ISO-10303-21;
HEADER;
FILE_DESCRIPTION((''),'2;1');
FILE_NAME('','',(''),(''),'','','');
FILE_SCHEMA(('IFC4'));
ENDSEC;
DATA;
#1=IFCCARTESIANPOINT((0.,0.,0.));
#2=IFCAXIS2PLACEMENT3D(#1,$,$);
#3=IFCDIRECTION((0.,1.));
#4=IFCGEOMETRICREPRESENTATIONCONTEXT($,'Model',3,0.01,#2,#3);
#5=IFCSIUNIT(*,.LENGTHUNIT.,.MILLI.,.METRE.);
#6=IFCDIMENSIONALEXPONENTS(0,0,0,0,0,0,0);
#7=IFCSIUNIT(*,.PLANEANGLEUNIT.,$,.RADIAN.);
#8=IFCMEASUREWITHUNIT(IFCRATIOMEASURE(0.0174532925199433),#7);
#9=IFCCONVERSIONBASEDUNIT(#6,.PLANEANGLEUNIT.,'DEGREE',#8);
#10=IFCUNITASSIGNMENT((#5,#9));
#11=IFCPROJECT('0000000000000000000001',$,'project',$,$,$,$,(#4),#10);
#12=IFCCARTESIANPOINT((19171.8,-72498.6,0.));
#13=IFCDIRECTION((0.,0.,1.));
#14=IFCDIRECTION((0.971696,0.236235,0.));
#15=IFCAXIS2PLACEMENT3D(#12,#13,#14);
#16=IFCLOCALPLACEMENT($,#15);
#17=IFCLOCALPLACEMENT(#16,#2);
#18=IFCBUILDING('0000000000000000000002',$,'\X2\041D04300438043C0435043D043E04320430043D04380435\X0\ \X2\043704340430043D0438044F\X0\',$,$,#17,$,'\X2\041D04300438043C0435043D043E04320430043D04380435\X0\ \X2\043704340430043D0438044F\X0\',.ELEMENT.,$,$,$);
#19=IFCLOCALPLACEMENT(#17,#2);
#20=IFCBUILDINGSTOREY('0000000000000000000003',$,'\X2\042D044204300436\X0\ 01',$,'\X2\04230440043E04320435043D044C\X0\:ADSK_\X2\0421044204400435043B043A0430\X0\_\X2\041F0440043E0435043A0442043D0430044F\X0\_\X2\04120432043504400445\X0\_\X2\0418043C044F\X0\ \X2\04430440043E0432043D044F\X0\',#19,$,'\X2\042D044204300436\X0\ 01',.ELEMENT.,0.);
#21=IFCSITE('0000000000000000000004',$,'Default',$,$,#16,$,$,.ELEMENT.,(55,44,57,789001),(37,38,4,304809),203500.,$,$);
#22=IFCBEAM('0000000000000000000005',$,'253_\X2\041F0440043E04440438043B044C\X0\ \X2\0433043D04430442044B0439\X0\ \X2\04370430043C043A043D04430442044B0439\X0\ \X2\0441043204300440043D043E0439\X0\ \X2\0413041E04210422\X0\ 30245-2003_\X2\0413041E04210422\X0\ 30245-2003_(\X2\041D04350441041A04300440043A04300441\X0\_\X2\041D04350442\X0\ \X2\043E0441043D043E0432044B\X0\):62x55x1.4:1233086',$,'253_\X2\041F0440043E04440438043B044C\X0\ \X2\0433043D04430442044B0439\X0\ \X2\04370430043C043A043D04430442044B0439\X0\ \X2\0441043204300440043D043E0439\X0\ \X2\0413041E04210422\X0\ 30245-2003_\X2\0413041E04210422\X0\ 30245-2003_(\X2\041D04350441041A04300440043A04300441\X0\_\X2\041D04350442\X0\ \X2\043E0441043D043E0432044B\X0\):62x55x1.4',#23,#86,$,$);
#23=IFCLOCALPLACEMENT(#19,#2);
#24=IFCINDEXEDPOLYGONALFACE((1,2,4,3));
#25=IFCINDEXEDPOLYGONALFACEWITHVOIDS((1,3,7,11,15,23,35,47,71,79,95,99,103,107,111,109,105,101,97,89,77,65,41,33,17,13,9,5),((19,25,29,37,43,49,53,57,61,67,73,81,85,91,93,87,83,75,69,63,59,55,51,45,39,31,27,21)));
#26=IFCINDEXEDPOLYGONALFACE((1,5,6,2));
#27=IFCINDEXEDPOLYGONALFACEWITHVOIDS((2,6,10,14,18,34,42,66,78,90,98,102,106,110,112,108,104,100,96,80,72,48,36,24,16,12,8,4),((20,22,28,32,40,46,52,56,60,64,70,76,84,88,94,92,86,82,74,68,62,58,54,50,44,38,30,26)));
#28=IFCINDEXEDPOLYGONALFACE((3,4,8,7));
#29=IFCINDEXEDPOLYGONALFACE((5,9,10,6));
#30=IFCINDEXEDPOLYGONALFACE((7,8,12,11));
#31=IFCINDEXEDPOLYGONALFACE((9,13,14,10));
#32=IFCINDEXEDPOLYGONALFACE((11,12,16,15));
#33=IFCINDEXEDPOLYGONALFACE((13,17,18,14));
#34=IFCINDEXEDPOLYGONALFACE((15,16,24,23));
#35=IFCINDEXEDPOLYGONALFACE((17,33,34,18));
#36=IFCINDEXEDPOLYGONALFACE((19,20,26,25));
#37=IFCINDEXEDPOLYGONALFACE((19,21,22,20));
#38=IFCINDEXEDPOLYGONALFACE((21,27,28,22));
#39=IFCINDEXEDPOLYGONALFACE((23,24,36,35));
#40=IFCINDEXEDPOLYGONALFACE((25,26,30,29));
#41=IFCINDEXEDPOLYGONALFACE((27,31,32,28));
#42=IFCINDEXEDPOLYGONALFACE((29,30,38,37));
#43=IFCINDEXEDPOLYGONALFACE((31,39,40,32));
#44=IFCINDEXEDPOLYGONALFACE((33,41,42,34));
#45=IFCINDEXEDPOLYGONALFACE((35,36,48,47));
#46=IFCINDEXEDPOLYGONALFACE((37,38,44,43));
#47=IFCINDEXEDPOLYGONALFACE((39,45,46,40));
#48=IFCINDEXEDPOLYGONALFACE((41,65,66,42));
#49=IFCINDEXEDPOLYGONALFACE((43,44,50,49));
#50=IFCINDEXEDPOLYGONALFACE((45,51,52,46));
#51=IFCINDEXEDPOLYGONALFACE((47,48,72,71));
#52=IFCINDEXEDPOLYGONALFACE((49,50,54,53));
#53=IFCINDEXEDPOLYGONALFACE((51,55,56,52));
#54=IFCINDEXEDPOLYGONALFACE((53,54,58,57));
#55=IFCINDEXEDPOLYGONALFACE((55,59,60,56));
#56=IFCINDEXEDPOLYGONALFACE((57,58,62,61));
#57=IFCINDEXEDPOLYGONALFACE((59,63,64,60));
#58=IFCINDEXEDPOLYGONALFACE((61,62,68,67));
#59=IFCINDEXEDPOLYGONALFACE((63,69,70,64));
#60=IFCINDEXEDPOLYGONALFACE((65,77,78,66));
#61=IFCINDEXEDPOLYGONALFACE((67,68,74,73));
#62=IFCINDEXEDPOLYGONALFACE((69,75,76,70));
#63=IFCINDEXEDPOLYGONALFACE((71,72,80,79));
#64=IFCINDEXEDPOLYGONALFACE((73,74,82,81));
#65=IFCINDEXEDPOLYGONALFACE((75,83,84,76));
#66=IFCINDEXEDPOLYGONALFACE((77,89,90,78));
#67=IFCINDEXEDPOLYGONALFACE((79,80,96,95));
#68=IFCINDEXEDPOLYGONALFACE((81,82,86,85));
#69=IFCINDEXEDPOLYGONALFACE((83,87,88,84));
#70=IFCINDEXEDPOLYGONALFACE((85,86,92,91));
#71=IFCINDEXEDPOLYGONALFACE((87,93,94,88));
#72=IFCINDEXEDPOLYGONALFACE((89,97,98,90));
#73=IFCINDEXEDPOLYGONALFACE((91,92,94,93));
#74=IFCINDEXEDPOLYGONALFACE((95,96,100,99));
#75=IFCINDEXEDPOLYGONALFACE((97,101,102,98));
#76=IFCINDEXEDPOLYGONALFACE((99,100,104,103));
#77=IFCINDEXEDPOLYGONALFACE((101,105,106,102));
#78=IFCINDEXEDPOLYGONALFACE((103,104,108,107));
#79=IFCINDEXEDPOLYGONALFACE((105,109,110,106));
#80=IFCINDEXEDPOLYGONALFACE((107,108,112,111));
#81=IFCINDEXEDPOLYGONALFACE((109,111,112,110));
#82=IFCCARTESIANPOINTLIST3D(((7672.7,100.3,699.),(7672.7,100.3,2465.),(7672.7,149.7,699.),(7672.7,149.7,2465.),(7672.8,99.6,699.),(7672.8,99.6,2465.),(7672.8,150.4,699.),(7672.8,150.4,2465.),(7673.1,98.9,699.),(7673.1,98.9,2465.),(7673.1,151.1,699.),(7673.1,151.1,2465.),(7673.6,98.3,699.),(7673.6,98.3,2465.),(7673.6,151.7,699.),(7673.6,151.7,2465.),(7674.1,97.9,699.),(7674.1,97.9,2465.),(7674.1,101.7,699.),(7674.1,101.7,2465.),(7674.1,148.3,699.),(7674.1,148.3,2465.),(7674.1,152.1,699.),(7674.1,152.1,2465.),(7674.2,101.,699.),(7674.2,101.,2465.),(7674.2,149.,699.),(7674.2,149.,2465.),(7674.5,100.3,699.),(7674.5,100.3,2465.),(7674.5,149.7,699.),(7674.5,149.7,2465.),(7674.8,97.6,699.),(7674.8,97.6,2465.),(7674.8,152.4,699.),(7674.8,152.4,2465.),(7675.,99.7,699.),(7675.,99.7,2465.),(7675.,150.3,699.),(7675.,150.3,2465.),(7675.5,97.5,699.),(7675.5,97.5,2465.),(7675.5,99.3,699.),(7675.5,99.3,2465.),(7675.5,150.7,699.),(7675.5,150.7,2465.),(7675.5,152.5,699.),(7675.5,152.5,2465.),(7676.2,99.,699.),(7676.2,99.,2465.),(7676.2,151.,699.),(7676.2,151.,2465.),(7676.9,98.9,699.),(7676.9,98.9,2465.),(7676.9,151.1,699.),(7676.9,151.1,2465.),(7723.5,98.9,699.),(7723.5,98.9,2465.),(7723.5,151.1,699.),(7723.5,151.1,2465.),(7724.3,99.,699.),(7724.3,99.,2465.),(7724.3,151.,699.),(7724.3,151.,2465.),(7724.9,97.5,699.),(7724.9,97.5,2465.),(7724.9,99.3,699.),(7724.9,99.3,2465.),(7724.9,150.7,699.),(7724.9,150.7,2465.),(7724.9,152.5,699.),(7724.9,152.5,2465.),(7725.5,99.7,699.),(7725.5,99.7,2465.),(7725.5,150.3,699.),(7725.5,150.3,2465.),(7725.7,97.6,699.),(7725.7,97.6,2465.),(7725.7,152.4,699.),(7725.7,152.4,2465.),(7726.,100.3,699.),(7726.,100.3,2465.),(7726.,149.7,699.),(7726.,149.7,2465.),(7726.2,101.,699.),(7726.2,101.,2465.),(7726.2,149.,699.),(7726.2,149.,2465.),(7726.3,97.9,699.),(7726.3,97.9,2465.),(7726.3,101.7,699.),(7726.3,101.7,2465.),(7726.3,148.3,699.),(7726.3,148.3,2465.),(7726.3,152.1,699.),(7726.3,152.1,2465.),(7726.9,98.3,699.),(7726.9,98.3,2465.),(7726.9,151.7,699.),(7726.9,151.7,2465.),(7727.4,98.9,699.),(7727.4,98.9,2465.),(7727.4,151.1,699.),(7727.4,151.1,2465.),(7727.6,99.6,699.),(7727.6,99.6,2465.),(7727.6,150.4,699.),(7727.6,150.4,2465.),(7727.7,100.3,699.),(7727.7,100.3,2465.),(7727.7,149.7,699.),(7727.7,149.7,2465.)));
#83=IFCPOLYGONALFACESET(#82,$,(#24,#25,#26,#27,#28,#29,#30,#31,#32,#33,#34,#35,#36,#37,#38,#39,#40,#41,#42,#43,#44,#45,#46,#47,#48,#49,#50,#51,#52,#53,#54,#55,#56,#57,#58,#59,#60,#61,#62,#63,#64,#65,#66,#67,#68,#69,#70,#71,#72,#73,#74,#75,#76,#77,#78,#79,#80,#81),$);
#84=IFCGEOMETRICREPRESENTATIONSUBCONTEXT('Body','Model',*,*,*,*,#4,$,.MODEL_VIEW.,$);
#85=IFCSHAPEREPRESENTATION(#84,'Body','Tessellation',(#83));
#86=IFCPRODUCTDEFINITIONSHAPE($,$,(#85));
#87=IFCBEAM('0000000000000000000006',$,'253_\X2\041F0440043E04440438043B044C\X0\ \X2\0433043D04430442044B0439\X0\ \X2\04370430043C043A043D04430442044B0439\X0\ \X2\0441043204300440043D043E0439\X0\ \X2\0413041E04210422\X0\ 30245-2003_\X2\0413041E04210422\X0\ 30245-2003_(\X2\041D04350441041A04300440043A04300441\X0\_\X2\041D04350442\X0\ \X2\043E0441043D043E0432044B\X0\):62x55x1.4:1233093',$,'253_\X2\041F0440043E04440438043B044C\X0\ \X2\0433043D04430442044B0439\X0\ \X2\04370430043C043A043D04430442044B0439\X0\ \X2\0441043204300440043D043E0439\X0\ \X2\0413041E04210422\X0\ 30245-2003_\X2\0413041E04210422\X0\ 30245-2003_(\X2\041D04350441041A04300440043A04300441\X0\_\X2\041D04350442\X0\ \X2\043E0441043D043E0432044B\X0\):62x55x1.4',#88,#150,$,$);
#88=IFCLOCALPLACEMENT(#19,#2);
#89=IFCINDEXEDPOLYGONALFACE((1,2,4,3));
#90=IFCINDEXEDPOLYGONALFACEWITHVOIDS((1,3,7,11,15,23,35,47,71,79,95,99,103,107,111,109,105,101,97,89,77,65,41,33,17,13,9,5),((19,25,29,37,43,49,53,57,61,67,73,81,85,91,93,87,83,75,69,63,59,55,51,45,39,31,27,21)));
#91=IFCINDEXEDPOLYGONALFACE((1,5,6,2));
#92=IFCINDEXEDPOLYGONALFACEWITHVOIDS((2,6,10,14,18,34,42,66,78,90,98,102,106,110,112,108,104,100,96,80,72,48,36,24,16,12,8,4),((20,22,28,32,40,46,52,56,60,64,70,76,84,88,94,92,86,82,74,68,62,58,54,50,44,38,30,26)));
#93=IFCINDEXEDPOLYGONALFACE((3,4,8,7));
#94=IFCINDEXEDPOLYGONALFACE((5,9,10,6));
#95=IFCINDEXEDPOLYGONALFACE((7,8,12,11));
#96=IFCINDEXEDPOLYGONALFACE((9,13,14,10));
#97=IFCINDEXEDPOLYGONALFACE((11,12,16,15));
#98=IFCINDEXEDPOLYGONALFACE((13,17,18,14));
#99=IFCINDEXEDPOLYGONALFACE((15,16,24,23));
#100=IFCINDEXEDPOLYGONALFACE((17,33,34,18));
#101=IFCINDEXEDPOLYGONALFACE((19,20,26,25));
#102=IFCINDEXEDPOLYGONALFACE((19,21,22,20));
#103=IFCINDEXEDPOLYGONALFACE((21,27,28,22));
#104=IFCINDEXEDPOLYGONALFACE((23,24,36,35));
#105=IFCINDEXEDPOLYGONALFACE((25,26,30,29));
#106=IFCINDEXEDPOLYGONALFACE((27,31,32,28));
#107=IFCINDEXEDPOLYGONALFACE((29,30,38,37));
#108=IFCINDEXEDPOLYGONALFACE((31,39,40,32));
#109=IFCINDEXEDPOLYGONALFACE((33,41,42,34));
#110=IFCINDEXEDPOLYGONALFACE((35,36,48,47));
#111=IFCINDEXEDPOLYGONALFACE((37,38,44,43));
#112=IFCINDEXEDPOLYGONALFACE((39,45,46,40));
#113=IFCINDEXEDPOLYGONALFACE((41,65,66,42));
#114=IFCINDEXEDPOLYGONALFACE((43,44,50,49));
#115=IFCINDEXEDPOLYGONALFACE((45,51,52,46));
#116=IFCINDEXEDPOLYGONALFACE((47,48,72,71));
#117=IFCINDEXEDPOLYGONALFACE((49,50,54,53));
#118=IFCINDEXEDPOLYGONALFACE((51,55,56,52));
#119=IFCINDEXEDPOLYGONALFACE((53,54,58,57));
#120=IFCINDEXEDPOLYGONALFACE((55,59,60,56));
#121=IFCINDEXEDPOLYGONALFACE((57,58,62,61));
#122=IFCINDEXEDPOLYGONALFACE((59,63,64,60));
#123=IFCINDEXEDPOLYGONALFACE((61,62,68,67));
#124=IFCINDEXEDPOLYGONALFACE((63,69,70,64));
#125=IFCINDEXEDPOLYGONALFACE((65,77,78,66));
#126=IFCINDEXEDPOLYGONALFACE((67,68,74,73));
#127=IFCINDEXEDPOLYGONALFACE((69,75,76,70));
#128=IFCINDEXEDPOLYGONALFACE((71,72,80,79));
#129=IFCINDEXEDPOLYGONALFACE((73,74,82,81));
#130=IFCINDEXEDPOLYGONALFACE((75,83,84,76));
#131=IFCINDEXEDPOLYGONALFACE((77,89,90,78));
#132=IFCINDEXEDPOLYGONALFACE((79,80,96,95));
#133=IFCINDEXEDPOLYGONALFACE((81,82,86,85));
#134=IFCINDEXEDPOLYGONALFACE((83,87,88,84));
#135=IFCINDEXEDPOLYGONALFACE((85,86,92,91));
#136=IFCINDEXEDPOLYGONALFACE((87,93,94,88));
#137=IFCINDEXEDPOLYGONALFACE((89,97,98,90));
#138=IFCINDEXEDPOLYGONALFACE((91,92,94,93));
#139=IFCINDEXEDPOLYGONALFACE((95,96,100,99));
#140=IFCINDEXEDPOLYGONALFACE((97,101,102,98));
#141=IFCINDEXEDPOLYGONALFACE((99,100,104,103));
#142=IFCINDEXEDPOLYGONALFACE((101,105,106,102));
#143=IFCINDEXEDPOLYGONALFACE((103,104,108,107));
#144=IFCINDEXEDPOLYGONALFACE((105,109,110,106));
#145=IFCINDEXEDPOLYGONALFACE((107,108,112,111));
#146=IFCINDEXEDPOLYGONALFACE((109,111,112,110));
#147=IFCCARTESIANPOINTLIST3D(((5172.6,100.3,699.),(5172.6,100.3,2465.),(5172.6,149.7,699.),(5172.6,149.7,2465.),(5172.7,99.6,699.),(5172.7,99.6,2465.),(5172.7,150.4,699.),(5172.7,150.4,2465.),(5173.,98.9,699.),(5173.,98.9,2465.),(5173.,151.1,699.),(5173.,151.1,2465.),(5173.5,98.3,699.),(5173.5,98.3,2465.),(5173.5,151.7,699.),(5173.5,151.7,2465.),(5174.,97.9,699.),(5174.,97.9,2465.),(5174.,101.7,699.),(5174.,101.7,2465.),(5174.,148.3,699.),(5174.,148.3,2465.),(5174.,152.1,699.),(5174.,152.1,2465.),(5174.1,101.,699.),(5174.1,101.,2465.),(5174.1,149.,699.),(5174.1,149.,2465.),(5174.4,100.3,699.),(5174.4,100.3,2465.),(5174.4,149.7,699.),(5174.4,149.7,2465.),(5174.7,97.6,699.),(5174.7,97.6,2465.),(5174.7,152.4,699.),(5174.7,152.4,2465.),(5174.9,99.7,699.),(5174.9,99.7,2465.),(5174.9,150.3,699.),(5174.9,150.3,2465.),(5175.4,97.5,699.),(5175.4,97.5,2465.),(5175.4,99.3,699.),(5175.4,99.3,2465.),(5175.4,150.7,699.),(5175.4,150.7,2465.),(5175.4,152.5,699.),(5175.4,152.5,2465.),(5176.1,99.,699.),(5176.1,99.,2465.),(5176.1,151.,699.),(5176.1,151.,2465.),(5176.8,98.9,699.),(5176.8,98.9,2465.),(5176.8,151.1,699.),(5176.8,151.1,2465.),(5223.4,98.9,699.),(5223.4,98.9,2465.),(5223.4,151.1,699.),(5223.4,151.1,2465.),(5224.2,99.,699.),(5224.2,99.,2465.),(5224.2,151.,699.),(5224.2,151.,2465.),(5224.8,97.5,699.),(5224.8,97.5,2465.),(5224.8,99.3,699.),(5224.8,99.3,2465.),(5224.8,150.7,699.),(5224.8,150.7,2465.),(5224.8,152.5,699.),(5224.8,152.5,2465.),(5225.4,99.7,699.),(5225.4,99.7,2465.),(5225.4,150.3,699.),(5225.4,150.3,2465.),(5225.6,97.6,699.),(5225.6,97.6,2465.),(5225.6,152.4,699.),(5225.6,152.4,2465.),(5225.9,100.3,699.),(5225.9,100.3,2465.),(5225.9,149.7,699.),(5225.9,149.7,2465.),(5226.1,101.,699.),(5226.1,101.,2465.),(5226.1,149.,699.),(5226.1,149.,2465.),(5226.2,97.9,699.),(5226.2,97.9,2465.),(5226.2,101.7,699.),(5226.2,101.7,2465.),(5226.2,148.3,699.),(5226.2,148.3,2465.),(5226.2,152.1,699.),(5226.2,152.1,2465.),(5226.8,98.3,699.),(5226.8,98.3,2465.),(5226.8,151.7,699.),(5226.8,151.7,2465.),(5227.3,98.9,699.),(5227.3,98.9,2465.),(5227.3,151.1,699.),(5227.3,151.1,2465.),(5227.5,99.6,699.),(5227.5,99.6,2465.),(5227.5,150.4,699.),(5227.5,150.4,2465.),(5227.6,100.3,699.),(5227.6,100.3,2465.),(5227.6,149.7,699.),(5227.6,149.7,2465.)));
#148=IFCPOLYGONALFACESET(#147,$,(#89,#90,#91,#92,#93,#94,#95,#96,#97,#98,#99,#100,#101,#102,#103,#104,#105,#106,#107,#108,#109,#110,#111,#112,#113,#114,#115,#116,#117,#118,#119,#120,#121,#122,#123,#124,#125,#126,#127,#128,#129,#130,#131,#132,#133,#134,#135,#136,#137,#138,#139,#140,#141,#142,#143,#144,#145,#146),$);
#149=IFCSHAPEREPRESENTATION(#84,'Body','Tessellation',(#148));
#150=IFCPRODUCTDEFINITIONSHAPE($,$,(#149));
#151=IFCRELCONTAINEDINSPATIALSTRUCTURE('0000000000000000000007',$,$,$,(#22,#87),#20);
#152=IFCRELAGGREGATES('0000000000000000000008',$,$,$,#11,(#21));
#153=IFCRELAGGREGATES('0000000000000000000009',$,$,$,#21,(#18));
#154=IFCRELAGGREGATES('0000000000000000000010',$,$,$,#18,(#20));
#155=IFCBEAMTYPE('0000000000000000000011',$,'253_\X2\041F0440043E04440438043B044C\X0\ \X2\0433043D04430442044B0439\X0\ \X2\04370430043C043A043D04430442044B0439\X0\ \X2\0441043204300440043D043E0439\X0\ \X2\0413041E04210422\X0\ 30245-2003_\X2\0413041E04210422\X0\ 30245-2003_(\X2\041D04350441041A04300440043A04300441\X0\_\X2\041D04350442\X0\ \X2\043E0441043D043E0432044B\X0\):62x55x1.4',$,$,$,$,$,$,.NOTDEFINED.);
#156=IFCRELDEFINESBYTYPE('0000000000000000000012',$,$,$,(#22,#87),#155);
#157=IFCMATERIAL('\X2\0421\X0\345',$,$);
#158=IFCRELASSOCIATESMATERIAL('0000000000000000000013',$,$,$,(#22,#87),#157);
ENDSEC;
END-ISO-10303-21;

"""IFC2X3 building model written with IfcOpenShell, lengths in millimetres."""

from ifc_helpers import new_model, entity, si_unit, converted_unit, direction, frame, frame_2d, origin, place, context, subcontext, project, spatial, polyline, circle_curve, parameter, trimmed, segment, composite_curve, outline, extrude, material, type_object, element, save


model = new_model("IFC2X3")

# Units and contexts
model_context = context("Model", 3, precision=0.01, world=origin(), true_north=direction((0.0, 1.0)))
body_context = subcontext(model_context, "Body", "Model", "MODEL_VIEW")
ifc_project = project(units=[si_unit("LENGTHUNIT", "METRE", prefix="MILLI"), converted_unit("PLANEANGLEUNIT", "DEGREE", entity("IfcRatioMeasure", 0.0174532925199433), si_unit("PLANEANGLEUNIT", "RADIAN"), dimensions=[0, 0, 0, 0, 0, 0, 0])], contexts=[model_context])

# Site, building, storey
site_placement = place(None, frame((19171.8, -72498.6, 0.0), z_axis=(0.0, 0.0, 1.0), x_axis=(0.971696, 0.236235, 0.0)))
site = spatial("IfcSite", under=ifc_project, at=site_placement, Name="Default", CompositionType="ELEMENT", RefLatitude=(55, 44, 57, 789001), RefLongitude=(37, 38, 4, 304809), RefElevation=203500.0)
building_placement = place(site_placement, origin())
building = spatial("IfcBuilding", under=site, at=building_placement, Name="Наименование здания", LongName="Наименование здания", CompositionType="ELEMENT")
storey_placement = place(building_placement, origin())
storey = spatial("IfcBuildingStorey", under=building, at=storey_placement, Name="Этаж 01", ObjectType="Уровень:ADSK_Стрелка_Проектная_Вверх_Имя уровня", LongName="Этаж 01", CompositionType="ELEMENT", Elevation=0.0)

# Beams
ifc_material_1 = material(Name="С345")
beam_type_1 = type_object("IfcBeamType", Name="253_Профиль гнутый замкнутый сварной ГОСТ 30245-2003_ГОСТ 30245-2003_(НесКаркас_Нет основы):62x55x1.4", PredefinedType="NOTDEFINED")
beam_1_placement = place(storey_placement, frame((7671.1, 95.9, 699.0), z_axis=(1.0, 0.0, 0.0), x_axis=(0.0, 0.0, 1.0)))
element("IfcBeam", 1, at=beam_1_placement, inside=storey, type_object=beam_type_1, material=ifc_material_1, Name="253_Профиль гнутый замкнутый сварной ГОСТ 30245-2003_ГОСТ 30245-2003_(НесКаркас_Нет основы):62x55x1.4:1233086", ObjectType="253_Профиль гнутый замкнутый сварной ГОСТ 30245-2003_ГОСТ 30245-2003_(НесКаркас_Нет основы):62x55x1.4", context=body_context, shape_type="SweptSolid", body=[
    extrude(outline(composite_curve([segment(trimmed(circle_curve(frame_2d((24.7, -24.7), x_axis=(1.0, 0.0)), 2.8), [parameter(270.0)], [parameter(0.0)], True, "PARAMETER"), True, "CONTINUOUS"), segment(polyline([(27.5, -24.7), (27.5, 24.7)]), True, "CONTINUOUS"), segment(trimmed(circle_curve(frame_2d((24.7, 24.7), x_axis=(1.0, 0.0)), 2.8), [parameter(0.0)], [parameter(90.0)], True, "PARAMETER"), True, "CONTINUOUS"), segment(polyline([(24.7, 27.5), (-24.7, 27.5)]), True, "CONTINUOUS"), segment(trimmed(circle_curve(frame_2d((-24.7, 24.7), x_axis=(1.0, 0.0)), 2.8), [parameter(90.0)], [parameter(180.0)], True, "PARAMETER"), True, "CONTINUOUS"), segment(polyline([(-27.5, 24.7), (-27.5, -24.7)]), True, "CONTINUOUS"), segment(trimmed(circle_curve(frame_2d((-24.7, -24.7), x_axis=(1.0, 0.0)), 2.8), [parameter(180.0)], [parameter(270.0)], True, "PARAMETER"), True, "CONTINUOUS"), segment(polyline([(-24.7, -27.5), (24.7, -27.5)]), True, "CONTINUOUS")], self_intersect=False), holes=[composite_curve([segment(polyline([(23.3, -26.1), (-23.3, -26.1)]), True, "CONTINUOUS"), segment(trimmed(circle_curve(frame_2d((-23.3, -23.3), x_axis=(1.0, 0.0)), 2.8), [parameter(180.0)], [parameter(270.0)], True, "PARAMETER"), False, "CONTINUOUS"), segment(polyline([(-26.1, -23.3), (-26.1, 23.3)]), True, "CONTINUOUS"), segment(trimmed(circle_curve(frame_2d((-23.3, 23.3), x_axis=(1.0, 0.0)), 2.8), [parameter(90.0)], [parameter(180.0)], True, "PARAMETER"), False, "CONTINUOUS"), segment(polyline([(-23.3, 26.1), (23.3, 26.1)]), True, "CONTINUOUS"), segment(trimmed(circle_curve(frame_2d((23.3, 23.3), x_axis=(1.0, 0.0)), 2.8), [parameter(0.0)], [parameter(90.0)], True, "PARAMETER"), False, "CONTINUOUS"), segment(polyline([(26.1, 23.3), (26.1, -23.3)]), True, "CONTINUOUS"), segment(trimmed(circle_curve(frame_2d((23.3, -23.3), x_axis=(1.0, 0.0)), 2.8), [parameter(270.0)], [parameter(0.0)], True, "PARAMETER"), False, "CONTINUOUS")], self_intersect=False)]), frame((0.0, -29.1, 29.1), z_axis=(1.0, 0.0, 0.0), x_axis=(0.0, -1.0, 0.0)), (0.0, 0.0, 1.0), 1766.0),
])
beam_2_placement = place(storey_placement, frame((5171.0, 95.9, 699.0), z_axis=(1.0, 0.0, 0.0), x_axis=(0.0, 0.0, 1.0)))
element("IfcBeam", 2, at=beam_2_placement, inside=storey, type_object=beam_type_1, material=ifc_material_1, Name="253_Профиль гнутый замкнутый сварной ГОСТ 30245-2003_ГОСТ 30245-2003_(НесКаркас_Нет основы):62x55x1.4:1233093", ObjectType="253_Профиль гнутый замкнутый сварной ГОСТ 30245-2003_ГОСТ 30245-2003_(НесКаркас_Нет основы):62x55x1.4", context=body_context, shape_type="SweptSolid", body=[
    extrude(outline(composite_curve([segment(trimmed(circle_curve(frame_2d((24.7, -24.7), x_axis=(1.0, 0.0)), 2.8), [parameter(270.0)], [parameter(0.0)], True, "PARAMETER"), True, "CONTINUOUS"), segment(polyline([(27.5, -24.7), (27.5, 24.7)]), True, "CONTINUOUS"), segment(trimmed(circle_curve(frame_2d((24.7, 24.7), x_axis=(1.0, 0.0)), 2.8), [parameter(0.0)], [parameter(90.0)], True, "PARAMETER"), True, "CONTINUOUS"), segment(polyline([(24.7, 27.5), (-24.7, 27.5)]), True, "CONTINUOUS"), segment(trimmed(circle_curve(frame_2d((-24.7, 24.7), x_axis=(1.0, 0.0)), 2.8), [parameter(90.0)], [parameter(180.0)], True, "PARAMETER"), True, "CONTINUOUS"), segment(polyline([(-27.5, 24.7), (-27.5, -24.7)]), True, "CONTINUOUS"), segment(trimmed(circle_curve(frame_2d((-24.7, -24.7), x_axis=(1.0, 0.0)), 2.8), [parameter(180.0)], [parameter(270.0)], True, "PARAMETER"), True, "CONTINUOUS"), segment(polyline([(-24.7, -27.5), (24.7, -27.5)]), True, "CONTINUOUS")], self_intersect=False), holes=[composite_curve([segment(polyline([(23.3, -26.1), (-23.3, -26.1)]), True, "CONTINUOUS"), segment(trimmed(circle_curve(frame_2d((-23.3, -23.3), x_axis=(1.0, 0.0)), 2.8), [parameter(180.0)], [parameter(270.0)], True, "PARAMETER"), False, "CONTINUOUS"), segment(polyline([(-26.1, -23.3), (-26.1, 23.3)]), True, "CONTINUOUS"), segment(trimmed(circle_curve(frame_2d((-23.3, 23.3), x_axis=(1.0, 0.0)), 2.8), [parameter(90.0)], [parameter(180.0)], True, "PARAMETER"), False, "CONTINUOUS"), segment(polyline([(-23.3, 26.1), (23.3, 26.1)]), True, "CONTINUOUS"), segment(trimmed(circle_curve(frame_2d((23.3, 23.3), x_axis=(1.0, 0.0)), 2.8), [parameter(0.0)], [parameter(90.0)], True, "PARAMETER"), False, "CONTINUOUS"), segment(polyline([(26.1, 23.3), (26.1, -23.3)]), True, "CONTINUOUS"), segment(trimmed(circle_curve(frame_2d((23.3, -23.3), x_axis=(1.0, 0.0)), 2.8), [parameter(270.0)], [parameter(0.0)], True, "PARAMETER"), False, "CONTINUOUS")], self_intersect=False)]), frame((0.0, -29.1, 29.1), z_axis=(1.0, 0.0, 0.0), x_axis=(0.0, -1.0, 0.0)), (0.0, 0.0, 1.0), 1766.0),
])

save(model, "model.ifc")
